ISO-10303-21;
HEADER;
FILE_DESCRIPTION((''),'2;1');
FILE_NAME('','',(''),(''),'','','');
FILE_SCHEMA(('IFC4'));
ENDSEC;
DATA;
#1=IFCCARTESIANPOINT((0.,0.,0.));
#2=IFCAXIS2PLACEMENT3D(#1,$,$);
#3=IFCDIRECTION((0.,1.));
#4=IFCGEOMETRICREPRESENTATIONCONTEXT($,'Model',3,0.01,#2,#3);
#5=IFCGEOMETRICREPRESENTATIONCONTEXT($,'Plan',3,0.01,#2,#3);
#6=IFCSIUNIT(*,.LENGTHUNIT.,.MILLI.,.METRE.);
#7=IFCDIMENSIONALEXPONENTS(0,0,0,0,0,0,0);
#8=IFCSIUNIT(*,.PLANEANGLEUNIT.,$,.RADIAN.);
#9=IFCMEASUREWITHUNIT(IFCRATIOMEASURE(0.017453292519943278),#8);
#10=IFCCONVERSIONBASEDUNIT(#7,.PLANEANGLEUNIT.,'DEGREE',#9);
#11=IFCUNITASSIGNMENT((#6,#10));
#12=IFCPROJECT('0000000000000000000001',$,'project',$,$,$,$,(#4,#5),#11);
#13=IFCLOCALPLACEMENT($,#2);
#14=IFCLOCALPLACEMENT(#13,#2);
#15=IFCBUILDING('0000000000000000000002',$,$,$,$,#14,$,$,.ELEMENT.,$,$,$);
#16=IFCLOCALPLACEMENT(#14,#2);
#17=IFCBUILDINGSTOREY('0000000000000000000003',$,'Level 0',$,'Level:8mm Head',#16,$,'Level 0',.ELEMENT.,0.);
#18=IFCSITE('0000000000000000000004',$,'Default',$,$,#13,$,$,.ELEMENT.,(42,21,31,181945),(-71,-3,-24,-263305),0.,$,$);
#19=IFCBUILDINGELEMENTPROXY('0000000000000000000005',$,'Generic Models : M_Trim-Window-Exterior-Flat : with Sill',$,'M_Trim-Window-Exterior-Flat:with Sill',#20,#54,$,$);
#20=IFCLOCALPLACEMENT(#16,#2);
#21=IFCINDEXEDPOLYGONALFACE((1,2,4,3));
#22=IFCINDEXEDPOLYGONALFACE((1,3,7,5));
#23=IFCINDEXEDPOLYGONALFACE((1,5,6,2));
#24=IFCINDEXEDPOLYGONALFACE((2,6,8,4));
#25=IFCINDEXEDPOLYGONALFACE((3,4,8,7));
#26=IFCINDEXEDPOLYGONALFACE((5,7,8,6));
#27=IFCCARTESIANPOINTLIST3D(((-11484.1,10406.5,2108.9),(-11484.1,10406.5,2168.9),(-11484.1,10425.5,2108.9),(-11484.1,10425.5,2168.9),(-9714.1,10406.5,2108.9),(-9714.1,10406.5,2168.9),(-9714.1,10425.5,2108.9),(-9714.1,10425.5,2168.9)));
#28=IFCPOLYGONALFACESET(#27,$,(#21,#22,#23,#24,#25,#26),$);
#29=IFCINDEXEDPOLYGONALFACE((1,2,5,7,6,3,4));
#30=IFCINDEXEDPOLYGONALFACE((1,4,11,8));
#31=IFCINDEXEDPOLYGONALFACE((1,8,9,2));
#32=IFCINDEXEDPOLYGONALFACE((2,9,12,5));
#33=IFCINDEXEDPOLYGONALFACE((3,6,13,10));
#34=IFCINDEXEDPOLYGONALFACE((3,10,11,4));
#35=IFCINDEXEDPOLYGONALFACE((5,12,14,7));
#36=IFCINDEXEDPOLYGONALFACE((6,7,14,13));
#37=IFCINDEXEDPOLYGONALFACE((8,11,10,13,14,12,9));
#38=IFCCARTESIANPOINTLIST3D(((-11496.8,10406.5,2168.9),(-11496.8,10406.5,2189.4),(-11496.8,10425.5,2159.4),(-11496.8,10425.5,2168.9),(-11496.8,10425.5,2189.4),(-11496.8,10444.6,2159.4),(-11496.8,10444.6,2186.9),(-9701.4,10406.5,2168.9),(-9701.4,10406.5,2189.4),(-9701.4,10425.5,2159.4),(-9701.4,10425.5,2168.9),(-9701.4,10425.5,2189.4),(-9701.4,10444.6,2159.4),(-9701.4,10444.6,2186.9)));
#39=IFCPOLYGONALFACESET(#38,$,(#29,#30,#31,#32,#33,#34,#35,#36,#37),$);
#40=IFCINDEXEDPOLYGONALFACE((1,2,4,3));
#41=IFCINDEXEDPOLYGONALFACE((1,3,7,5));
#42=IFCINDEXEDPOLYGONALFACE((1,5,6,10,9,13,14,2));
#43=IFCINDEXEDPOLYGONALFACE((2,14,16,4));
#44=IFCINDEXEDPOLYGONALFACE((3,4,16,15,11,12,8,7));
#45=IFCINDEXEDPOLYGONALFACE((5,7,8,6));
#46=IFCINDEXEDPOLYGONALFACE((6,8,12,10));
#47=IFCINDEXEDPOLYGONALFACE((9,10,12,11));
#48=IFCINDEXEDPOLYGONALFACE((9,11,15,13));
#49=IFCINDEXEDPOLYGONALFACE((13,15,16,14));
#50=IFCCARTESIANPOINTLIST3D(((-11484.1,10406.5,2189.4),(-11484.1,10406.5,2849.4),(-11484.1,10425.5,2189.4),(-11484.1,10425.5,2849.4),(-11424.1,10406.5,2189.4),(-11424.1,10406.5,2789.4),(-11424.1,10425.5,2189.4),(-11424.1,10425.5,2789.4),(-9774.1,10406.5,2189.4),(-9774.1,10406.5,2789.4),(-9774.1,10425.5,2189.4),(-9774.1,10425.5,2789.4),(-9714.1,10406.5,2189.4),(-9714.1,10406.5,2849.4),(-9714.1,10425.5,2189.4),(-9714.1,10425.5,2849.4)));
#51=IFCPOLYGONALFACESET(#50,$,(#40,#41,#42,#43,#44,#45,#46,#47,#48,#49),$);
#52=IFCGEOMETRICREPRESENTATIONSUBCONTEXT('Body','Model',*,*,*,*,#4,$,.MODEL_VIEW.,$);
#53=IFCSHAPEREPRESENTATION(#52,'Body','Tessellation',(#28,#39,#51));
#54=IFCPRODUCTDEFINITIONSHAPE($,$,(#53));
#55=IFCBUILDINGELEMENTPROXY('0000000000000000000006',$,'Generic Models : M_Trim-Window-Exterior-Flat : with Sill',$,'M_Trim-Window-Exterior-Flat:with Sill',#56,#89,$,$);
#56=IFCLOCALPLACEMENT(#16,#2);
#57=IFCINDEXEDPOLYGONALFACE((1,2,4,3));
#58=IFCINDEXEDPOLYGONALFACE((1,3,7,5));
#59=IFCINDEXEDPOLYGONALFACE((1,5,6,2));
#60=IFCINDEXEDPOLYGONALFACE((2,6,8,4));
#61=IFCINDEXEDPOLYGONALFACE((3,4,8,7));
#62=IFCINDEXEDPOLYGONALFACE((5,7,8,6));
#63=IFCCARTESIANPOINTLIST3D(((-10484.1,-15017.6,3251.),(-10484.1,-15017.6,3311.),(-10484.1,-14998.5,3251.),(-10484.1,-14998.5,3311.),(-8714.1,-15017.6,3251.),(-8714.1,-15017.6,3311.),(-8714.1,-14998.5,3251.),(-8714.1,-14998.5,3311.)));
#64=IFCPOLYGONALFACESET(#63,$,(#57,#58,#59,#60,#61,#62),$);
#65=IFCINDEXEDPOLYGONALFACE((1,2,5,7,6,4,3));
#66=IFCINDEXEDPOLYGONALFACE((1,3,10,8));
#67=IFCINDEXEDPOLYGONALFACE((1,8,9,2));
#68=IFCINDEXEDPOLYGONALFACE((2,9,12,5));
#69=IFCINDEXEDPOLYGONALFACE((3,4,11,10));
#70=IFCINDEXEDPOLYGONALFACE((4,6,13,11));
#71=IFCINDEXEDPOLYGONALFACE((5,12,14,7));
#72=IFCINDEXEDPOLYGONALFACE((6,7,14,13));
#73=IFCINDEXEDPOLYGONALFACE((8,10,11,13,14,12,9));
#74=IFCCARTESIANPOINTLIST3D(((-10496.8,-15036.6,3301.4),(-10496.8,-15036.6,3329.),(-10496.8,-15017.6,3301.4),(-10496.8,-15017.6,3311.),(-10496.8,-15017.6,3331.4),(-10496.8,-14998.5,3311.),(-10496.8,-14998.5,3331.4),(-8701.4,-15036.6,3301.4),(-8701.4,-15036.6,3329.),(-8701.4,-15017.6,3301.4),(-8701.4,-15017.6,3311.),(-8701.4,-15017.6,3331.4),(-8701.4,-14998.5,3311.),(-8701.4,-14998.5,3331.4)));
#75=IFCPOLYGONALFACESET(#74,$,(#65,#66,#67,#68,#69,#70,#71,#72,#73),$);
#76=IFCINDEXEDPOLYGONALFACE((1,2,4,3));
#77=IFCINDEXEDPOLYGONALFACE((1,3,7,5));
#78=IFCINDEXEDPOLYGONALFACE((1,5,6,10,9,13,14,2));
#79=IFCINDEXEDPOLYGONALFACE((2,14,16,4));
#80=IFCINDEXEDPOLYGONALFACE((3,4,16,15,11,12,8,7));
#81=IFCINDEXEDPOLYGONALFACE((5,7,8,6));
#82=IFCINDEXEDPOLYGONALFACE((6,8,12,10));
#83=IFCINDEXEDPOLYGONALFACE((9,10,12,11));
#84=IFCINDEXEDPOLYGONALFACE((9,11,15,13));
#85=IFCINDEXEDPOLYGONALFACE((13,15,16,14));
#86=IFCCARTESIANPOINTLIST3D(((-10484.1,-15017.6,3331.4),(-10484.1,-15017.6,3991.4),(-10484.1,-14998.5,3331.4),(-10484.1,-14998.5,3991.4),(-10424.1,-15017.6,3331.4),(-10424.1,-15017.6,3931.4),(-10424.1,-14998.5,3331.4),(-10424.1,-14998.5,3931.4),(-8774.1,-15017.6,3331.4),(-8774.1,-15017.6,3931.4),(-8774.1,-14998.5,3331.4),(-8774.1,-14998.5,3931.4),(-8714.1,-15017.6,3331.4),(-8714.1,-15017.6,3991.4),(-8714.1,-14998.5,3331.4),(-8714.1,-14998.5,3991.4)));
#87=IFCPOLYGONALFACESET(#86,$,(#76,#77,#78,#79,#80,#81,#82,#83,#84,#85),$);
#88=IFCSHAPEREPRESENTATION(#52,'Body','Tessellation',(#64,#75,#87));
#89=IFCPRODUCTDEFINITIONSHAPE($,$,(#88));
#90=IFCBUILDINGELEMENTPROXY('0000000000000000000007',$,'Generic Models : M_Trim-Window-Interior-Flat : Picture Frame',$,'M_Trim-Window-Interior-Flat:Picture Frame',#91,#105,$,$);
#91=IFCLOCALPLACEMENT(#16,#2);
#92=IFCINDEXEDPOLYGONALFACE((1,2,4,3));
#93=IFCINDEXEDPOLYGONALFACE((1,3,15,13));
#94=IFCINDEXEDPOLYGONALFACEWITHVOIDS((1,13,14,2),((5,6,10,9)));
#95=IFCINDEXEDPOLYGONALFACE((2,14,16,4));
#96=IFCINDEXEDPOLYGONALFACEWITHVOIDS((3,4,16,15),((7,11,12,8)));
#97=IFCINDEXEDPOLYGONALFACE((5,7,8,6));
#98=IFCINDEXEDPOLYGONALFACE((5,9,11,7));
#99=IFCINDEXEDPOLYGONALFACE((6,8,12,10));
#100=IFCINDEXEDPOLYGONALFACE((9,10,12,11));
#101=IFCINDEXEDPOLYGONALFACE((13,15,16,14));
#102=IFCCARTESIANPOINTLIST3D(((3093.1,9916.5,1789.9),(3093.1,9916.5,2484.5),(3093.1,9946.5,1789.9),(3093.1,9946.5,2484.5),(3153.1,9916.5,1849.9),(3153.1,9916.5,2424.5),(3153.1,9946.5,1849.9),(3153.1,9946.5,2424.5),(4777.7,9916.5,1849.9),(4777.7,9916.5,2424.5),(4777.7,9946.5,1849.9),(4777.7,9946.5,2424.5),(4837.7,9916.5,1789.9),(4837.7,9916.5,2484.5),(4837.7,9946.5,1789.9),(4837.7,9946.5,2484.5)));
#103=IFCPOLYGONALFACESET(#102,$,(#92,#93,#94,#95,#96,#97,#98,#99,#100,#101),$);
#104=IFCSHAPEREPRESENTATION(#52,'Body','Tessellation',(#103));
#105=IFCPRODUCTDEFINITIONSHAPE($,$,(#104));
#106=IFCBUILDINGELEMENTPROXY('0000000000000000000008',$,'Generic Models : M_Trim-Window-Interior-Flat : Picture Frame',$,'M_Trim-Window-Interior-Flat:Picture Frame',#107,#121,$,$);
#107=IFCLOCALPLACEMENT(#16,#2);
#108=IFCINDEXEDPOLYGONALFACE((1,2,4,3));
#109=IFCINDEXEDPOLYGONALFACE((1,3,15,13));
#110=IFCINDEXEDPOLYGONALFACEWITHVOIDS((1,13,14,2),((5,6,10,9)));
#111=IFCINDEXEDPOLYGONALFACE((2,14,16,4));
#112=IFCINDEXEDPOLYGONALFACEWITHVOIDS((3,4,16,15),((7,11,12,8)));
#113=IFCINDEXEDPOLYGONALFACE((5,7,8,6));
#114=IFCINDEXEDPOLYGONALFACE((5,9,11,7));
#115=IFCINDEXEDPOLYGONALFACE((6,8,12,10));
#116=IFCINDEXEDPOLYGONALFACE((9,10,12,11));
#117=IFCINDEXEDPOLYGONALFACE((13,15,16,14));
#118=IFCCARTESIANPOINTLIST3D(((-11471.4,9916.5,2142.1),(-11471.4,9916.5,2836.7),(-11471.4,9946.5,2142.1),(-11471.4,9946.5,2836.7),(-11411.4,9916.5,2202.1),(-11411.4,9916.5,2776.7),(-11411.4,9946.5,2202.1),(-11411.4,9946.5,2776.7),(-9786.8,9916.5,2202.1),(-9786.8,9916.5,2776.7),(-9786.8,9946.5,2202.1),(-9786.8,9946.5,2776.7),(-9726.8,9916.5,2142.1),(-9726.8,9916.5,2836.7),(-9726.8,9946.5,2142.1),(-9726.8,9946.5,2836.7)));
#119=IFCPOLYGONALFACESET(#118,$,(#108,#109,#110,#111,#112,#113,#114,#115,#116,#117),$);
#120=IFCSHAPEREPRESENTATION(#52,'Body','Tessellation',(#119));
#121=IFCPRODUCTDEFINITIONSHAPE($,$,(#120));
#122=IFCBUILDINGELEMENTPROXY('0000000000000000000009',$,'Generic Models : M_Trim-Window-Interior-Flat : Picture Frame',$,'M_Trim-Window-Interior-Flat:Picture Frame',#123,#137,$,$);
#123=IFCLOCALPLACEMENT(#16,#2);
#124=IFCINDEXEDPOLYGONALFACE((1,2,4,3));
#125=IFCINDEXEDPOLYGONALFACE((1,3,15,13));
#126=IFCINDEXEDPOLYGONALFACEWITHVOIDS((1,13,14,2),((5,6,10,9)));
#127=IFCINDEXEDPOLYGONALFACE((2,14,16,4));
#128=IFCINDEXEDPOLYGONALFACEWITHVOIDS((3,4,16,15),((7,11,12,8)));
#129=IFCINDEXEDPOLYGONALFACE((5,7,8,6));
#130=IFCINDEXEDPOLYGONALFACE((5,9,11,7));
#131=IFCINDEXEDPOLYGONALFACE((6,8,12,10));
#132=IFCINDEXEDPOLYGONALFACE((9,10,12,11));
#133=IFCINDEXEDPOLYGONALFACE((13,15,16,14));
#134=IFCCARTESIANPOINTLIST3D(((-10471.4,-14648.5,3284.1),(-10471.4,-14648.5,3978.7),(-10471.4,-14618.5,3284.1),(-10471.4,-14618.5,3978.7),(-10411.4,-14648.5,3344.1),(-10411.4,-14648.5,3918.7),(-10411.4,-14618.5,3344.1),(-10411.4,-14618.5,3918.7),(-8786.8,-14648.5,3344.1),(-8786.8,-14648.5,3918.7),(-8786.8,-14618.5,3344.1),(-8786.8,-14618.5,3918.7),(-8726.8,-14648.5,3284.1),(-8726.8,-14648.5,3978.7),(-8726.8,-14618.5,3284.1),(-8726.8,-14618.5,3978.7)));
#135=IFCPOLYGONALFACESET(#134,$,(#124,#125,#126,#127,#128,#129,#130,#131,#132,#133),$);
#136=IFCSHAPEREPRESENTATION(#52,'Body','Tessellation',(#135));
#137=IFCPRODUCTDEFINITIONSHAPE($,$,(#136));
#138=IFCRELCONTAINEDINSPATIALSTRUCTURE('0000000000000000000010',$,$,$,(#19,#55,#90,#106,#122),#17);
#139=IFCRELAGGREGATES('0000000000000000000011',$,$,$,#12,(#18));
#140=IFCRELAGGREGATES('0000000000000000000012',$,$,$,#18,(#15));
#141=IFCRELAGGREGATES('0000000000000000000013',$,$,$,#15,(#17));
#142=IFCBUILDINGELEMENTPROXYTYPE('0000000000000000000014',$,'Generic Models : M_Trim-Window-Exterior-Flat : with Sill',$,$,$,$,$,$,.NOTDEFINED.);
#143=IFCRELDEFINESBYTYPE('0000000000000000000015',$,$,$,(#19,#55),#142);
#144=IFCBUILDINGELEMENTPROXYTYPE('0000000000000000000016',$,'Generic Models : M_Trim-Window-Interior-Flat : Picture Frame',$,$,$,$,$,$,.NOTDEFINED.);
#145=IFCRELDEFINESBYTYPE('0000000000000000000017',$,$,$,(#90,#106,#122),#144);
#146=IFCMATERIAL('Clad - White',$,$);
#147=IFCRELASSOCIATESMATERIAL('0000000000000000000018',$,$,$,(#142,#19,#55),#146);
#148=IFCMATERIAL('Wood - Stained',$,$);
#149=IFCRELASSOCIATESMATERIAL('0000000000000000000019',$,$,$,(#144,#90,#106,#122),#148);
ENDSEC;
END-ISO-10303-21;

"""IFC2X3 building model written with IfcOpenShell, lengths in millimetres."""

from ifc_helpers import new_model, entity, si_unit, converted_unit, direction, frame, frame_2d, origin, place, context, subcontext, project, spatial, polyline, rectangle, outline, extrude, source, transform, mapped, material, type_object, type_shapes, element, save


model = new_model("IFC2X3")

# Units and contexts
model_context = context("Model", 3, precision=0.01, world=origin(), true_north=direction((0.0, 1.0)))
plan_context = context("Plan", 3, precision=0.01, world=origin(), true_north=direction((0.0, 1.0)))
body_context = subcontext(model_context, "Body", "Model", "MODEL_VIEW")
ifc_project = project(units=[si_unit("LENGTHUNIT", "METRE", prefix="MILLI"), converted_unit("PLANEANGLEUNIT", "DEGREE", entity("IfcRatioMeasure", 0.017453292519943278), si_unit("PLANEANGLEUNIT", "RADIAN"), dimensions=[0, 0, 0, 0, 0, 0, 0])], contexts=[model_context, plan_context])

# Site, building, storey
site_placement = place(None, origin())
site = spatial("IfcSite", under=ifc_project, at=site_placement, Name="Default", CompositionType="ELEMENT", RefLatitude=(42, 21, 31, 181945), RefLongitude=(-71, -3, -24, -263305), RefElevation=0.0)
building_placement = place(site_placement, origin())
building = spatial("IfcBuilding", under=site, at=building_placement, CompositionType="ELEMENT")
storey_placement = place(building_placement, origin())
storey = spatial("IfcBuildingStorey", under=building, at=storey_placement, Name="Level 0", ObjectType="Level:8mm Head", LongName="Level 0", CompositionType="ELEMENT", Elevation=0.0)

# Building element proxies
ifc_material_1 = material(Name="Clad - White")
building_element_proxy_type_1 = type_object("IfcBuildingElementProxyType", Name="Generic Models : M_Trim-Window-Exterior-Flat : with Sill", PredefinedType="NOTDEFINED", material=ifc_material_1)
shared_shape_1 = source(origin(), body_context, "Body", "SweptSolid", [
    extrude(rectangle(XDim=1770.0, YDim=60.0, at=frame_2d((0.0, 0.0), x_axis=(1.0, 0.0))), frame((0.0, -650.4, 0.0), z_axis=(0.0, 0.0, 1.0), x_axis=(-1.0, 0.0, 0.0)), (0.0, 0.0, 1.0), 19.0),
    extrude(outline(polyline([(-19.0, -15.2), (0.0, -15.2), (0.0, -5.7), (19.0, -5.7), (19.0, 14.8), (0.0, 14.8), (-19.0, 12.3), (-19.0, -15.2)])), frame((-897.7, -614.8, 19.0), z_axis=(1.0, 0.0, 0.0), x_axis=(0.0, 0.0, -1.0)), (0.0, 0.0, 1.0), 1795.4),
    extrude(outline(polyline([(-345.0, -885.0), (315.0, -885.0), (315.0, -825.0), (-285.0, -825.0), (-285.0, 825.0), (315.0, 825.0), (315.0, 885.0), (-345.0, 885.0), (-345.0, -885.0)])), frame((0.0, -285.0, 0.0), z_axis=(0.0, 0.0, 1.0), x_axis=(0.0, -1.0, 0.0)), (0.0, 0.0, 1.0), 19.0),
])
type_shapes(building_element_proxy_type_1, [shared_shape_1])
for number, where, z_axis, x_axis, name in (
    (1, (-10599.1, 10406.5, 2789.4), (0.0, 1.0, 0.0), (-1.0, 0.0, 0.0), "Generic Models : M_Trim-Window-Exterior-Flat : with Sill"),
    (2, (-9599.1, -14998.5, 3931.4), (0.0, -1.0, 0.0), (1.0, 0.0, 0.0), "Generic Models : M_Trim-Window-Exterior-Flat : with Sill"),
):
    element("IfcBuildingElementProxy", number, at=place(storey_placement, frame(where, z_axis=z_axis, x_axis=x_axis)), inside=storey, type_object=building_element_proxy_type_1, material=ifc_material_1, Name=name, ObjectType="M_Trim-Window-Exterior-Flat:with Sill", context=body_context, shape_type="MappedRepresentation", body=[
        mapped(shared_shape_1, transform((0.0, 0.0, 0.0), scale=1.0)),
    ])
ifc_material_2 = material(Name="Wood - Stained")
building_element_proxy_type_2 = type_object("IfcBuildingElementProxyType", Name="Generic Models : M_Trim-Window-Interior-Flat : Picture Frame", PredefinedType="NOTDEFINED", material=ifc_material_2)
shared_shape_2 = source(origin(), body_context, "Body", "SweptSolid", [
    extrude(outline(polyline([(-872.3, -347.3), (872.3, -347.3), (872.3, 347.3), (-872.3, 347.3), (-872.3, -347.3)]), holes=[polyline([(-812.3, -287.3), (-812.3, 287.3), (812.3, 287.3), (812.3, -287.3), (-812.3, -287.3)])]), frame((0.0, -300.0, 0.0), z_axis=(0.0, 0.0, 1.0), x_axis=(-1.0, 0.0, 0.0)), (0.0, 0.0, 1.0), 30.0),
])
type_shapes(building_element_proxy_type_2, [shared_shape_2])
for number, where, z_axis, x_axis, name in (
    (3, (3965.4, 9946.5, 2437.2), (0.0, -1.0, 0.0), (1.0, 0.0, 0.0), "Generic Models : M_Trim-Window-Interior-Flat : Picture Frame"),
    (4, (-10599.1, 9946.5, 2789.4), (0.0, -1.0, 0.0), (1.0, 0.0, 0.0), "Generic Models : M_Trim-Window-Interior-Flat : Picture Frame"),
    (5, (-9599.1, -14648.5, 3931.4), (0.0, 1.0, 0.0), (-1.0, 0.0, 0.0), "Generic Models : M_Trim-Window-Interior-Flat : Picture Frame"),
):
    element("IfcBuildingElementProxy", number, at=place(storey_placement, frame(where, z_axis=z_axis, x_axis=x_axis)), inside=storey, type_object=building_element_proxy_type_2, material=ifc_material_2, Name=name, ObjectType="M_Trim-Window-Interior-Flat:Picture Frame", context=body_context, shape_type="MappedRepresentation", body=[
        mapped(shared_shape_2, transform((0.0, 0.0, 0.0), scale=1.0)),
    ])

save(model, "model.ifc")
